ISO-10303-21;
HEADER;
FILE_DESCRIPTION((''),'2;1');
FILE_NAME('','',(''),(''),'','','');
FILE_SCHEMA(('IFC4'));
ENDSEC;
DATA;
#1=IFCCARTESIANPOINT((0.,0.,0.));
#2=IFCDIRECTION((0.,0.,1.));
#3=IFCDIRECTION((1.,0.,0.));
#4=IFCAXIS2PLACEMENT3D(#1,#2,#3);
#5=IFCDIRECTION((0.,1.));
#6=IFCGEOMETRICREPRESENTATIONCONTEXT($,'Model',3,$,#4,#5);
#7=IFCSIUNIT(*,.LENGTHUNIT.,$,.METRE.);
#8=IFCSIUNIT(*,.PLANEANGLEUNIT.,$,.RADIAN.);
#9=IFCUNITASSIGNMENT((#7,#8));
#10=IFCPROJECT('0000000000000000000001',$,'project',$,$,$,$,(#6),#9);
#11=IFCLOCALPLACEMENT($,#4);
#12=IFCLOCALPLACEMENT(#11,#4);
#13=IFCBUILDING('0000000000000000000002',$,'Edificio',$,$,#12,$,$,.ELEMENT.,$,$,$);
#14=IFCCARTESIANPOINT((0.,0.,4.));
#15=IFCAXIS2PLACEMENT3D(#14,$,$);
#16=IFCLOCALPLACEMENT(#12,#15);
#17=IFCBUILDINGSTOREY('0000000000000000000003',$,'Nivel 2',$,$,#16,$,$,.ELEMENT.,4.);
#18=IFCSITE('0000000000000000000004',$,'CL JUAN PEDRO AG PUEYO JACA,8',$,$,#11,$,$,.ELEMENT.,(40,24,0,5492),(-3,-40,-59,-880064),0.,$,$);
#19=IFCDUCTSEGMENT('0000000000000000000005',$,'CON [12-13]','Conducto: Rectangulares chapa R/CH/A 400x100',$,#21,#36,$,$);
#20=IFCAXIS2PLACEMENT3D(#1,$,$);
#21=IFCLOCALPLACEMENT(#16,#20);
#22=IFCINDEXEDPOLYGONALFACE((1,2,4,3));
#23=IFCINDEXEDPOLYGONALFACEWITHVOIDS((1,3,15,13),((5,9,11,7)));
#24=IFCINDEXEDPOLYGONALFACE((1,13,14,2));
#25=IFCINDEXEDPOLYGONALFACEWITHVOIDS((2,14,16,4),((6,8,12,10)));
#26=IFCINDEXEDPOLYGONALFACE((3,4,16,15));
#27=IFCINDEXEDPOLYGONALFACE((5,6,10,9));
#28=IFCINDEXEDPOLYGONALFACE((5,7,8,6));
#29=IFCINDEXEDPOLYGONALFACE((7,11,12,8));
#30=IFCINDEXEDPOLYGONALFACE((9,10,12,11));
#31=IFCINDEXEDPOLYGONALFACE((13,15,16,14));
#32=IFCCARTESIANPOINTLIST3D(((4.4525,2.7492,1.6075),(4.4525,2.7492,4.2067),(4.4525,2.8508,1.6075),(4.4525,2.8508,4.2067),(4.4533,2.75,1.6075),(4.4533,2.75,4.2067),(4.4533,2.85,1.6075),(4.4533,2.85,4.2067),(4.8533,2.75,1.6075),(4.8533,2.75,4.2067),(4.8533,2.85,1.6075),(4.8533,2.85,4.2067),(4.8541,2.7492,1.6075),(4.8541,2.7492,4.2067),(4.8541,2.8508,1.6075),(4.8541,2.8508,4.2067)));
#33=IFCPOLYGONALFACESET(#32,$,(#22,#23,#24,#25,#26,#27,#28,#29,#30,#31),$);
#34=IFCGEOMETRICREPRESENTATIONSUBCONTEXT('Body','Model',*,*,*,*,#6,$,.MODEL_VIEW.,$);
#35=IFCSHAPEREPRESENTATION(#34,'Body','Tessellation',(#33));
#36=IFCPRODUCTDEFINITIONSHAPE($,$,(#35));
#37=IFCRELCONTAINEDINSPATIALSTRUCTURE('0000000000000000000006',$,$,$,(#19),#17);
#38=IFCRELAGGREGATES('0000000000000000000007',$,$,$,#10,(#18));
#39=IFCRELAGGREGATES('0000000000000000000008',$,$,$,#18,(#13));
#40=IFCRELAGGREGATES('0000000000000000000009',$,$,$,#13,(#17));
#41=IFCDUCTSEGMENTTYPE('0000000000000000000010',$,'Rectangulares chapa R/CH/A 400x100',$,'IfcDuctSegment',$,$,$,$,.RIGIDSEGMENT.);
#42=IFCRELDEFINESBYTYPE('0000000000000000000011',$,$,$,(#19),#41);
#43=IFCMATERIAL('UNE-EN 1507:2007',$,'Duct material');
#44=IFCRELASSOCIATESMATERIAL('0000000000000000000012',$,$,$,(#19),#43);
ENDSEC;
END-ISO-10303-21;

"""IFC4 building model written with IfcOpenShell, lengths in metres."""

from ifc_helpers import new_model, si_unit, direction, frame, origin_with_axes, origin_2d_with_axis, place, context, subcontext, project, spatial, hollow_rectangle, extrude, material, type_object, element, save


model = new_model("IFC4")

# Units and contexts
model_context = context("Model", 3, world=origin_with_axes(), true_north=direction((0.0, 1.0)))
body_context = subcontext(model_context, "Body", "Model", "MODEL_VIEW")
ifc_project = project(units=[si_unit("LENGTHUNIT", "METRE"), si_unit("PLANEANGLEUNIT", "RADIAN")], contexts=[model_context])

# Site, building, storey
site_placement = place(None, origin_with_axes())
site = spatial("IfcSite", under=ifc_project, at=site_placement, Name="CL JUAN PEDRO AG PUEYO JACA,8", CompositionType="ELEMENT", RefLatitude=(40, 24, 0, 5492), RefLongitude=(-3, -40, -59, -880064), RefElevation=0.0)
building_placement = place(site_placement, origin_with_axes())
building = spatial("IfcBuilding", under=site, at=building_placement, Name="Edificio", CompositionType="ELEMENT")
storey_placement = place(building_placement, frame((0.0, 0.0, 4.0)))
storey = spatial("IfcBuildingStorey", under=building, at=storey_placement, Name="Nivel 2", CompositionType="ELEMENT", Elevation=4.0)

# Duct segment
ifc_material_1 = material(Name="UNE-EN 1507:2007", Category="Duct material")
duct_segment_type_1 = type_object("IfcDuctSegmentType", Name="Rectangulares chapa R/CH/A 400x100", ApplicableOccurrence="IfcDuctSegment", PredefinedType="RIGIDSEGMENT")
duct_segment_1_placement = place(storey_placement, frame((0.0, 0.0, -4.0), z_axis=(0.0, 0.0, 1.0), x_axis=(1.0, 0.0, 0.0)))
element("IfcDuctSegment", 1, at=duct_segment_1_placement, inside=storey, type_object=duct_segment_type_1, material=ifc_material_1, Name="CON [12-13]", Description="Conducto: Rectangulares chapa R/CH/A 400x100", context=body_context, shape_type="SweptSolid", body=[
    extrude(hollow_rectangle(XDim=0.4016, YDim=0.1016, WallThickness=0.0008, at=origin_2d_with_axis()), frame((4.6533, 2.8, 8.2067), z_axis=(0.0, 0.0, -1.0), x_axis=(1.0, 0.0, 0.0)), (0.0, 0.0, 1.0), 2.5992),
])

save(model, "model.ifc")
